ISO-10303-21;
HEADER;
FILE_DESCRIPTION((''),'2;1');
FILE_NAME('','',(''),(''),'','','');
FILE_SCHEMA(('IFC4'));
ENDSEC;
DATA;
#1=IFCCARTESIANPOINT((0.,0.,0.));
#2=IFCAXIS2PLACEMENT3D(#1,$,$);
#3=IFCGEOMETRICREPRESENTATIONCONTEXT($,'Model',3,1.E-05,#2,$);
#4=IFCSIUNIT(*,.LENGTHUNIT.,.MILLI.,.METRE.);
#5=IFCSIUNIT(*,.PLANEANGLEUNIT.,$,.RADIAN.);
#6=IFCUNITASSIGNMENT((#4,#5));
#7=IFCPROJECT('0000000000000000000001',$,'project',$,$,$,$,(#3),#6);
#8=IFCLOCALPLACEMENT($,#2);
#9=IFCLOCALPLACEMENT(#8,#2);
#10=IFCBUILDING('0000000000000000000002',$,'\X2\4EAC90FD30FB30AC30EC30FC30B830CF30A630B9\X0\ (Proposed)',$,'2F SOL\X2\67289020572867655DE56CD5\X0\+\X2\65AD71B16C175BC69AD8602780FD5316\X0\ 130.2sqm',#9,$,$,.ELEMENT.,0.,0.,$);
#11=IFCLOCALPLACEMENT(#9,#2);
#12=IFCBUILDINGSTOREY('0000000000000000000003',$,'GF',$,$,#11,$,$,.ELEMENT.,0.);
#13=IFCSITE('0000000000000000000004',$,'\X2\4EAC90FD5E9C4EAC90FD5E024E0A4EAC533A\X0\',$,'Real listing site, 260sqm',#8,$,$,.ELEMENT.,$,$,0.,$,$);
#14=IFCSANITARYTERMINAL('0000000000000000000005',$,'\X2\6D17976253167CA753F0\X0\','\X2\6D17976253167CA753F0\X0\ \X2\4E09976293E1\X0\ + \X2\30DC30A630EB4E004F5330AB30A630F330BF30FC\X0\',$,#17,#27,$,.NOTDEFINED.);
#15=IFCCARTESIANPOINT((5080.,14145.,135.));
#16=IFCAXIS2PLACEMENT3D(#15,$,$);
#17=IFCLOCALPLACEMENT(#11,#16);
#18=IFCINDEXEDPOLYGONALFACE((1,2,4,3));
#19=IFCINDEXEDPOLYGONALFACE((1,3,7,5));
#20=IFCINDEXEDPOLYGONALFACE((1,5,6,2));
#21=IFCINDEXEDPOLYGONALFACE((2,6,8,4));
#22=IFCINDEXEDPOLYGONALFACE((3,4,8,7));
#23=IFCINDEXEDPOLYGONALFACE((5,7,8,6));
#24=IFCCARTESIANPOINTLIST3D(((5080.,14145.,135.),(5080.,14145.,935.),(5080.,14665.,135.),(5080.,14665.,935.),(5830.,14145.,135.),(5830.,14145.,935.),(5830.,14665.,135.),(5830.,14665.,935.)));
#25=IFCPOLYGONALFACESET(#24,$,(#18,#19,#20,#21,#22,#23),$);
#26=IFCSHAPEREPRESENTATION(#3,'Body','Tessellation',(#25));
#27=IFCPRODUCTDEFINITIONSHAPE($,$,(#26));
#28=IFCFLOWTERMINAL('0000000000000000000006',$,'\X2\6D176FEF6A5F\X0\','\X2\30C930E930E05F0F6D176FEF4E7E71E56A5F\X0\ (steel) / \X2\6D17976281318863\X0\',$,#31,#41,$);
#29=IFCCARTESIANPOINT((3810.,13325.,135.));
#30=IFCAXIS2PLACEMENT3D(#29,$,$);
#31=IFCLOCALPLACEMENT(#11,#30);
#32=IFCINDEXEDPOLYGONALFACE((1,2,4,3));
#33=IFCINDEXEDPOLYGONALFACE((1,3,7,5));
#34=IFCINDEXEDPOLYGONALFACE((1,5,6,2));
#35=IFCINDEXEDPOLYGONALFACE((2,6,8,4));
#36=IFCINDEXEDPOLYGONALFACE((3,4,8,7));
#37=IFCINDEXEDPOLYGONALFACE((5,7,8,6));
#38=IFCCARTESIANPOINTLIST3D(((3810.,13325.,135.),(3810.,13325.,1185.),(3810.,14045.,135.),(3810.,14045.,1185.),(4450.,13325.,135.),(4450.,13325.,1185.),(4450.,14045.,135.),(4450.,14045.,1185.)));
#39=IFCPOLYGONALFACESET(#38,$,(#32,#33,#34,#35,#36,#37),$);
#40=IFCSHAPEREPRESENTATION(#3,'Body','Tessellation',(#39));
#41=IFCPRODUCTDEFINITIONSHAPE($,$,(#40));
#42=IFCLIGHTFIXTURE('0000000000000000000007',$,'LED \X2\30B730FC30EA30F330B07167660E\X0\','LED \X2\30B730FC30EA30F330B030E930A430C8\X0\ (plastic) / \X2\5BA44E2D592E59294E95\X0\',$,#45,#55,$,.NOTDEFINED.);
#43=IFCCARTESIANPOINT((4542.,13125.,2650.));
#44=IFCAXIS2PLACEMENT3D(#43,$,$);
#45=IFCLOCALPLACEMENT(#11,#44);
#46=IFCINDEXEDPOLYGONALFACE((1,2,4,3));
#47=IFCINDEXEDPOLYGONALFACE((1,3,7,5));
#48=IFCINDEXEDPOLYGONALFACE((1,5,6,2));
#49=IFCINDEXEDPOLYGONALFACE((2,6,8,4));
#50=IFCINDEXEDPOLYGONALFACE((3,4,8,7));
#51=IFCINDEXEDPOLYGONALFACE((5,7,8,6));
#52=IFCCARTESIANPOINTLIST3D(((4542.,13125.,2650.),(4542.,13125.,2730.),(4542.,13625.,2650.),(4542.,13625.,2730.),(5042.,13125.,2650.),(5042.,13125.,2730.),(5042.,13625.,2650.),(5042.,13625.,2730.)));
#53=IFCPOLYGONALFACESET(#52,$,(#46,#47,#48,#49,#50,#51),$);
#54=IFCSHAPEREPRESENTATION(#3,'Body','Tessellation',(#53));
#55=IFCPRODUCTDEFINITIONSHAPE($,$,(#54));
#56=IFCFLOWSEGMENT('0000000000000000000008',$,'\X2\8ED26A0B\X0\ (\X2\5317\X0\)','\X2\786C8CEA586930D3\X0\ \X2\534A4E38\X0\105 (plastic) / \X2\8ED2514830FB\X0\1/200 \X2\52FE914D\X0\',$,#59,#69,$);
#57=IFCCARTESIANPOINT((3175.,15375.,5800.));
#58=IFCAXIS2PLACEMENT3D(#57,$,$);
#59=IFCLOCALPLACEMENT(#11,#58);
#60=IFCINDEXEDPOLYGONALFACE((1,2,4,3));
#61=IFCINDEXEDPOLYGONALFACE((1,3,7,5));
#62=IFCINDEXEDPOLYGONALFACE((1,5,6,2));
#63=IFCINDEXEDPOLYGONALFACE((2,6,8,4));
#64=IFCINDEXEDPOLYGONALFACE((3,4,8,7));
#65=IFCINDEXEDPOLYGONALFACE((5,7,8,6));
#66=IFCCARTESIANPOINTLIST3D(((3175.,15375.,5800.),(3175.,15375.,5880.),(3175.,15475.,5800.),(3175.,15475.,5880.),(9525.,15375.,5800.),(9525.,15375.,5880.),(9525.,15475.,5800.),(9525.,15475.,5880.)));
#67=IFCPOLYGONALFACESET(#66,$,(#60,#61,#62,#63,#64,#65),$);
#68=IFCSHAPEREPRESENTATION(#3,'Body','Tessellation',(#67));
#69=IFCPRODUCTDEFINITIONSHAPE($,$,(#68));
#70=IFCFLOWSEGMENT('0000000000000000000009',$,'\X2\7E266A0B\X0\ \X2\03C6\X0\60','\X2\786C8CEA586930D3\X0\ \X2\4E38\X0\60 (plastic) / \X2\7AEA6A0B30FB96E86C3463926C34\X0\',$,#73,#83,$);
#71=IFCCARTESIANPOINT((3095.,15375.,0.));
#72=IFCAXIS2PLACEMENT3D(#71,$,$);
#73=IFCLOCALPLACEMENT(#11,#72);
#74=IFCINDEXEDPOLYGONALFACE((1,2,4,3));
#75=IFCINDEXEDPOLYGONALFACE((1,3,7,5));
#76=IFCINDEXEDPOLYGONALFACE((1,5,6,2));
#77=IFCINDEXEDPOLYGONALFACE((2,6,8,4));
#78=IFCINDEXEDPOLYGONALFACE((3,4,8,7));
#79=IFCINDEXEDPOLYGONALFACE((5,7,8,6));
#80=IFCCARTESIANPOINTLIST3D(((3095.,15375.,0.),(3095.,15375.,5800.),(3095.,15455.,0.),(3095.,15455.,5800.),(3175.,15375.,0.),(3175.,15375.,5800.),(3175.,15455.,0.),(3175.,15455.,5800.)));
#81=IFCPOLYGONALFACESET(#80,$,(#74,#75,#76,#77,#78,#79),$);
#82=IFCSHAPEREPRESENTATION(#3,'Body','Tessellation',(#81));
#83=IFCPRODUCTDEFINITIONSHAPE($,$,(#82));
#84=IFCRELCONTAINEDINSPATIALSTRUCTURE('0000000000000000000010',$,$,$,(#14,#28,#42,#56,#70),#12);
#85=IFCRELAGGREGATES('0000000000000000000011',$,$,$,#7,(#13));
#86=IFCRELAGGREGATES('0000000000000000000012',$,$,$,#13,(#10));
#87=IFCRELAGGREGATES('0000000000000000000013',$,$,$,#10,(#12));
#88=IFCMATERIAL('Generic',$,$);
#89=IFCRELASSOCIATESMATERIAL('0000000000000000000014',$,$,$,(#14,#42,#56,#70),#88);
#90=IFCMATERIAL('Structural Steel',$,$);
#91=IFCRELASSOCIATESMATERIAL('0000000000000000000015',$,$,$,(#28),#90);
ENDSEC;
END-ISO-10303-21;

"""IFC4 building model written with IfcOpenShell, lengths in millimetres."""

from ifc_helpers import new_model, si_unit, frame, frame_2d, origin, place, context, project, spatial, rectangle, extrude, material, element, save


model = new_model("IFC4")

# Units and contexts
model_context = context("Model", 3, precision=1e-05, world=origin())
ifc_project = project(units=[si_unit("LENGTHUNIT", "METRE", prefix="MILLI"), si_unit("PLANEANGLEUNIT", "RADIAN")], contexts=[model_context])

# Site, building, storey
site_placement = place(None, origin())
site = spatial("IfcSite", under=ifc_project, at=site_placement, Name="京都府京都市上京区", ObjectType="Real listing site, 260sqm", CompositionType="ELEMENT", RefElevation=0.0)
building_placement = place(site_placement, origin())
building = spatial("IfcBuilding", under=site, at=building_placement, Name="京都・ガレージハウス (Proposed)", ObjectType="2F SOL木造在来工法+断熱気密高性能化 130.2sqm", CompositionType="ELEMENT", ElevationOfRefHeight=0.0, ElevationOfTerrain=0.0)
storey_placement = place(building_placement, origin())
storey = spatial("IfcBuildingStorey", under=building, at=storey_placement, Name="GF", CompositionType="ELEMENT", Elevation=0.0)

# Sanitary terminal
ifc_material_1 = material(Name="Generic")
sanitary_terminal_placement = place(storey_placement, frame((5080.0, 14145.0, 135.0)))
element("IfcSanitaryTerminal", 1, at=sanitary_terminal_placement, inside=storey, material=ifc_material_1, Name="洗面化粧台", Description="洗面化粧台 三面鏡 + ボウル一体カウンター", PredefinedType="NOTDEFINED", context=model_context, shape_type="SweptSolid", body=[
    extrude(rectangle(XDim=750.0, YDim=520.0, at=frame_2d((375.0, 260.0))), frame((5080.0, 14145.0, 135.0)), (0.0, 0.0, 1.0), 800.0),
])

# Flow terminal
ifc_material_2 = material(Name="Structural Steel")
flow_terminal_placement = place(storey_placement, frame((3810.0, 13325.0, 135.0)))
element("IfcFlowTerminal", 2, at=flow_terminal_placement, inside=storey, material=ifc_material_2, Name="洗濯機", Description="ドラム式洗濯乾燥機 (steel) / 洗面脱衣", context=model_context, shape_type="SweptSolid", body=[
    extrude(rectangle(XDim=640.0, YDim=720.0, at=frame_2d((320.0, 360.0))), frame((3810.0, 13325.0, 135.0)), (0.0, 0.0, 1.0), 1050.0),
])

# Light fixture
light_fixture_placement = place(storey_placement, frame((4542.0, 13125.0, 2650.0)))
element("IfcLightFixture", 3, at=light_fixture_placement, inside=storey, material=ifc_material_1, Name="LED シーリング照明", Description="LED シーリングライト (plastic) / 室中央天井", PredefinedType="NOTDEFINED", context=model_context, shape_type="SweptSolid", body=[
    extrude(rectangle(XDim=500.0, YDim=500.0, at=frame_2d((250.0, 250.0))), frame((4542.0, 13125.0, 2650.0)), (0.0, 0.0, 1.0), 80.0),
])

# Flow segments
flow_segment_1_placement = place(storey_placement, frame((3175.0, 15375.0, 5800.0)))
element("IfcFlowSegment", 4, at=flow_segment_1_placement, inside=storey, material=ifc_material_1, Name="軒樋 (北)", Description="硬質塩ビ 半丸105 (plastic) / 軒先・1/200 勾配", context=model_context, shape_type="SweptSolid", body=[
    extrude(rectangle(XDim=6350.0, YDim=100.0, at=frame_2d((3175.0, 50.0))), frame((3175.0, 15375.0, 5800.0)), (0.0, 0.0, 1.0), 80.0),
])
flow_segment_2_placement = place(storey_placement, frame((3095.0, 15375.0, 0.0)))
element("IfcFlowSegment", 5, at=flow_segment_2_placement, inside=storey, material=ifc_material_1, Name="縦樋 φ60", Description="硬質塩ビ 丸60 (plastic) / 竪樋・雨水排水", context=model_context, shape_type="SweptSolid", body=[
    extrude(rectangle(XDim=80.0, YDim=80.0, at=frame_2d((40.0, 40.0))), frame((3095.0, 15375.0, 0.0)), (0.0, 0.0, 1.0), 5800.0),
])

save(model, "model.ifc")
